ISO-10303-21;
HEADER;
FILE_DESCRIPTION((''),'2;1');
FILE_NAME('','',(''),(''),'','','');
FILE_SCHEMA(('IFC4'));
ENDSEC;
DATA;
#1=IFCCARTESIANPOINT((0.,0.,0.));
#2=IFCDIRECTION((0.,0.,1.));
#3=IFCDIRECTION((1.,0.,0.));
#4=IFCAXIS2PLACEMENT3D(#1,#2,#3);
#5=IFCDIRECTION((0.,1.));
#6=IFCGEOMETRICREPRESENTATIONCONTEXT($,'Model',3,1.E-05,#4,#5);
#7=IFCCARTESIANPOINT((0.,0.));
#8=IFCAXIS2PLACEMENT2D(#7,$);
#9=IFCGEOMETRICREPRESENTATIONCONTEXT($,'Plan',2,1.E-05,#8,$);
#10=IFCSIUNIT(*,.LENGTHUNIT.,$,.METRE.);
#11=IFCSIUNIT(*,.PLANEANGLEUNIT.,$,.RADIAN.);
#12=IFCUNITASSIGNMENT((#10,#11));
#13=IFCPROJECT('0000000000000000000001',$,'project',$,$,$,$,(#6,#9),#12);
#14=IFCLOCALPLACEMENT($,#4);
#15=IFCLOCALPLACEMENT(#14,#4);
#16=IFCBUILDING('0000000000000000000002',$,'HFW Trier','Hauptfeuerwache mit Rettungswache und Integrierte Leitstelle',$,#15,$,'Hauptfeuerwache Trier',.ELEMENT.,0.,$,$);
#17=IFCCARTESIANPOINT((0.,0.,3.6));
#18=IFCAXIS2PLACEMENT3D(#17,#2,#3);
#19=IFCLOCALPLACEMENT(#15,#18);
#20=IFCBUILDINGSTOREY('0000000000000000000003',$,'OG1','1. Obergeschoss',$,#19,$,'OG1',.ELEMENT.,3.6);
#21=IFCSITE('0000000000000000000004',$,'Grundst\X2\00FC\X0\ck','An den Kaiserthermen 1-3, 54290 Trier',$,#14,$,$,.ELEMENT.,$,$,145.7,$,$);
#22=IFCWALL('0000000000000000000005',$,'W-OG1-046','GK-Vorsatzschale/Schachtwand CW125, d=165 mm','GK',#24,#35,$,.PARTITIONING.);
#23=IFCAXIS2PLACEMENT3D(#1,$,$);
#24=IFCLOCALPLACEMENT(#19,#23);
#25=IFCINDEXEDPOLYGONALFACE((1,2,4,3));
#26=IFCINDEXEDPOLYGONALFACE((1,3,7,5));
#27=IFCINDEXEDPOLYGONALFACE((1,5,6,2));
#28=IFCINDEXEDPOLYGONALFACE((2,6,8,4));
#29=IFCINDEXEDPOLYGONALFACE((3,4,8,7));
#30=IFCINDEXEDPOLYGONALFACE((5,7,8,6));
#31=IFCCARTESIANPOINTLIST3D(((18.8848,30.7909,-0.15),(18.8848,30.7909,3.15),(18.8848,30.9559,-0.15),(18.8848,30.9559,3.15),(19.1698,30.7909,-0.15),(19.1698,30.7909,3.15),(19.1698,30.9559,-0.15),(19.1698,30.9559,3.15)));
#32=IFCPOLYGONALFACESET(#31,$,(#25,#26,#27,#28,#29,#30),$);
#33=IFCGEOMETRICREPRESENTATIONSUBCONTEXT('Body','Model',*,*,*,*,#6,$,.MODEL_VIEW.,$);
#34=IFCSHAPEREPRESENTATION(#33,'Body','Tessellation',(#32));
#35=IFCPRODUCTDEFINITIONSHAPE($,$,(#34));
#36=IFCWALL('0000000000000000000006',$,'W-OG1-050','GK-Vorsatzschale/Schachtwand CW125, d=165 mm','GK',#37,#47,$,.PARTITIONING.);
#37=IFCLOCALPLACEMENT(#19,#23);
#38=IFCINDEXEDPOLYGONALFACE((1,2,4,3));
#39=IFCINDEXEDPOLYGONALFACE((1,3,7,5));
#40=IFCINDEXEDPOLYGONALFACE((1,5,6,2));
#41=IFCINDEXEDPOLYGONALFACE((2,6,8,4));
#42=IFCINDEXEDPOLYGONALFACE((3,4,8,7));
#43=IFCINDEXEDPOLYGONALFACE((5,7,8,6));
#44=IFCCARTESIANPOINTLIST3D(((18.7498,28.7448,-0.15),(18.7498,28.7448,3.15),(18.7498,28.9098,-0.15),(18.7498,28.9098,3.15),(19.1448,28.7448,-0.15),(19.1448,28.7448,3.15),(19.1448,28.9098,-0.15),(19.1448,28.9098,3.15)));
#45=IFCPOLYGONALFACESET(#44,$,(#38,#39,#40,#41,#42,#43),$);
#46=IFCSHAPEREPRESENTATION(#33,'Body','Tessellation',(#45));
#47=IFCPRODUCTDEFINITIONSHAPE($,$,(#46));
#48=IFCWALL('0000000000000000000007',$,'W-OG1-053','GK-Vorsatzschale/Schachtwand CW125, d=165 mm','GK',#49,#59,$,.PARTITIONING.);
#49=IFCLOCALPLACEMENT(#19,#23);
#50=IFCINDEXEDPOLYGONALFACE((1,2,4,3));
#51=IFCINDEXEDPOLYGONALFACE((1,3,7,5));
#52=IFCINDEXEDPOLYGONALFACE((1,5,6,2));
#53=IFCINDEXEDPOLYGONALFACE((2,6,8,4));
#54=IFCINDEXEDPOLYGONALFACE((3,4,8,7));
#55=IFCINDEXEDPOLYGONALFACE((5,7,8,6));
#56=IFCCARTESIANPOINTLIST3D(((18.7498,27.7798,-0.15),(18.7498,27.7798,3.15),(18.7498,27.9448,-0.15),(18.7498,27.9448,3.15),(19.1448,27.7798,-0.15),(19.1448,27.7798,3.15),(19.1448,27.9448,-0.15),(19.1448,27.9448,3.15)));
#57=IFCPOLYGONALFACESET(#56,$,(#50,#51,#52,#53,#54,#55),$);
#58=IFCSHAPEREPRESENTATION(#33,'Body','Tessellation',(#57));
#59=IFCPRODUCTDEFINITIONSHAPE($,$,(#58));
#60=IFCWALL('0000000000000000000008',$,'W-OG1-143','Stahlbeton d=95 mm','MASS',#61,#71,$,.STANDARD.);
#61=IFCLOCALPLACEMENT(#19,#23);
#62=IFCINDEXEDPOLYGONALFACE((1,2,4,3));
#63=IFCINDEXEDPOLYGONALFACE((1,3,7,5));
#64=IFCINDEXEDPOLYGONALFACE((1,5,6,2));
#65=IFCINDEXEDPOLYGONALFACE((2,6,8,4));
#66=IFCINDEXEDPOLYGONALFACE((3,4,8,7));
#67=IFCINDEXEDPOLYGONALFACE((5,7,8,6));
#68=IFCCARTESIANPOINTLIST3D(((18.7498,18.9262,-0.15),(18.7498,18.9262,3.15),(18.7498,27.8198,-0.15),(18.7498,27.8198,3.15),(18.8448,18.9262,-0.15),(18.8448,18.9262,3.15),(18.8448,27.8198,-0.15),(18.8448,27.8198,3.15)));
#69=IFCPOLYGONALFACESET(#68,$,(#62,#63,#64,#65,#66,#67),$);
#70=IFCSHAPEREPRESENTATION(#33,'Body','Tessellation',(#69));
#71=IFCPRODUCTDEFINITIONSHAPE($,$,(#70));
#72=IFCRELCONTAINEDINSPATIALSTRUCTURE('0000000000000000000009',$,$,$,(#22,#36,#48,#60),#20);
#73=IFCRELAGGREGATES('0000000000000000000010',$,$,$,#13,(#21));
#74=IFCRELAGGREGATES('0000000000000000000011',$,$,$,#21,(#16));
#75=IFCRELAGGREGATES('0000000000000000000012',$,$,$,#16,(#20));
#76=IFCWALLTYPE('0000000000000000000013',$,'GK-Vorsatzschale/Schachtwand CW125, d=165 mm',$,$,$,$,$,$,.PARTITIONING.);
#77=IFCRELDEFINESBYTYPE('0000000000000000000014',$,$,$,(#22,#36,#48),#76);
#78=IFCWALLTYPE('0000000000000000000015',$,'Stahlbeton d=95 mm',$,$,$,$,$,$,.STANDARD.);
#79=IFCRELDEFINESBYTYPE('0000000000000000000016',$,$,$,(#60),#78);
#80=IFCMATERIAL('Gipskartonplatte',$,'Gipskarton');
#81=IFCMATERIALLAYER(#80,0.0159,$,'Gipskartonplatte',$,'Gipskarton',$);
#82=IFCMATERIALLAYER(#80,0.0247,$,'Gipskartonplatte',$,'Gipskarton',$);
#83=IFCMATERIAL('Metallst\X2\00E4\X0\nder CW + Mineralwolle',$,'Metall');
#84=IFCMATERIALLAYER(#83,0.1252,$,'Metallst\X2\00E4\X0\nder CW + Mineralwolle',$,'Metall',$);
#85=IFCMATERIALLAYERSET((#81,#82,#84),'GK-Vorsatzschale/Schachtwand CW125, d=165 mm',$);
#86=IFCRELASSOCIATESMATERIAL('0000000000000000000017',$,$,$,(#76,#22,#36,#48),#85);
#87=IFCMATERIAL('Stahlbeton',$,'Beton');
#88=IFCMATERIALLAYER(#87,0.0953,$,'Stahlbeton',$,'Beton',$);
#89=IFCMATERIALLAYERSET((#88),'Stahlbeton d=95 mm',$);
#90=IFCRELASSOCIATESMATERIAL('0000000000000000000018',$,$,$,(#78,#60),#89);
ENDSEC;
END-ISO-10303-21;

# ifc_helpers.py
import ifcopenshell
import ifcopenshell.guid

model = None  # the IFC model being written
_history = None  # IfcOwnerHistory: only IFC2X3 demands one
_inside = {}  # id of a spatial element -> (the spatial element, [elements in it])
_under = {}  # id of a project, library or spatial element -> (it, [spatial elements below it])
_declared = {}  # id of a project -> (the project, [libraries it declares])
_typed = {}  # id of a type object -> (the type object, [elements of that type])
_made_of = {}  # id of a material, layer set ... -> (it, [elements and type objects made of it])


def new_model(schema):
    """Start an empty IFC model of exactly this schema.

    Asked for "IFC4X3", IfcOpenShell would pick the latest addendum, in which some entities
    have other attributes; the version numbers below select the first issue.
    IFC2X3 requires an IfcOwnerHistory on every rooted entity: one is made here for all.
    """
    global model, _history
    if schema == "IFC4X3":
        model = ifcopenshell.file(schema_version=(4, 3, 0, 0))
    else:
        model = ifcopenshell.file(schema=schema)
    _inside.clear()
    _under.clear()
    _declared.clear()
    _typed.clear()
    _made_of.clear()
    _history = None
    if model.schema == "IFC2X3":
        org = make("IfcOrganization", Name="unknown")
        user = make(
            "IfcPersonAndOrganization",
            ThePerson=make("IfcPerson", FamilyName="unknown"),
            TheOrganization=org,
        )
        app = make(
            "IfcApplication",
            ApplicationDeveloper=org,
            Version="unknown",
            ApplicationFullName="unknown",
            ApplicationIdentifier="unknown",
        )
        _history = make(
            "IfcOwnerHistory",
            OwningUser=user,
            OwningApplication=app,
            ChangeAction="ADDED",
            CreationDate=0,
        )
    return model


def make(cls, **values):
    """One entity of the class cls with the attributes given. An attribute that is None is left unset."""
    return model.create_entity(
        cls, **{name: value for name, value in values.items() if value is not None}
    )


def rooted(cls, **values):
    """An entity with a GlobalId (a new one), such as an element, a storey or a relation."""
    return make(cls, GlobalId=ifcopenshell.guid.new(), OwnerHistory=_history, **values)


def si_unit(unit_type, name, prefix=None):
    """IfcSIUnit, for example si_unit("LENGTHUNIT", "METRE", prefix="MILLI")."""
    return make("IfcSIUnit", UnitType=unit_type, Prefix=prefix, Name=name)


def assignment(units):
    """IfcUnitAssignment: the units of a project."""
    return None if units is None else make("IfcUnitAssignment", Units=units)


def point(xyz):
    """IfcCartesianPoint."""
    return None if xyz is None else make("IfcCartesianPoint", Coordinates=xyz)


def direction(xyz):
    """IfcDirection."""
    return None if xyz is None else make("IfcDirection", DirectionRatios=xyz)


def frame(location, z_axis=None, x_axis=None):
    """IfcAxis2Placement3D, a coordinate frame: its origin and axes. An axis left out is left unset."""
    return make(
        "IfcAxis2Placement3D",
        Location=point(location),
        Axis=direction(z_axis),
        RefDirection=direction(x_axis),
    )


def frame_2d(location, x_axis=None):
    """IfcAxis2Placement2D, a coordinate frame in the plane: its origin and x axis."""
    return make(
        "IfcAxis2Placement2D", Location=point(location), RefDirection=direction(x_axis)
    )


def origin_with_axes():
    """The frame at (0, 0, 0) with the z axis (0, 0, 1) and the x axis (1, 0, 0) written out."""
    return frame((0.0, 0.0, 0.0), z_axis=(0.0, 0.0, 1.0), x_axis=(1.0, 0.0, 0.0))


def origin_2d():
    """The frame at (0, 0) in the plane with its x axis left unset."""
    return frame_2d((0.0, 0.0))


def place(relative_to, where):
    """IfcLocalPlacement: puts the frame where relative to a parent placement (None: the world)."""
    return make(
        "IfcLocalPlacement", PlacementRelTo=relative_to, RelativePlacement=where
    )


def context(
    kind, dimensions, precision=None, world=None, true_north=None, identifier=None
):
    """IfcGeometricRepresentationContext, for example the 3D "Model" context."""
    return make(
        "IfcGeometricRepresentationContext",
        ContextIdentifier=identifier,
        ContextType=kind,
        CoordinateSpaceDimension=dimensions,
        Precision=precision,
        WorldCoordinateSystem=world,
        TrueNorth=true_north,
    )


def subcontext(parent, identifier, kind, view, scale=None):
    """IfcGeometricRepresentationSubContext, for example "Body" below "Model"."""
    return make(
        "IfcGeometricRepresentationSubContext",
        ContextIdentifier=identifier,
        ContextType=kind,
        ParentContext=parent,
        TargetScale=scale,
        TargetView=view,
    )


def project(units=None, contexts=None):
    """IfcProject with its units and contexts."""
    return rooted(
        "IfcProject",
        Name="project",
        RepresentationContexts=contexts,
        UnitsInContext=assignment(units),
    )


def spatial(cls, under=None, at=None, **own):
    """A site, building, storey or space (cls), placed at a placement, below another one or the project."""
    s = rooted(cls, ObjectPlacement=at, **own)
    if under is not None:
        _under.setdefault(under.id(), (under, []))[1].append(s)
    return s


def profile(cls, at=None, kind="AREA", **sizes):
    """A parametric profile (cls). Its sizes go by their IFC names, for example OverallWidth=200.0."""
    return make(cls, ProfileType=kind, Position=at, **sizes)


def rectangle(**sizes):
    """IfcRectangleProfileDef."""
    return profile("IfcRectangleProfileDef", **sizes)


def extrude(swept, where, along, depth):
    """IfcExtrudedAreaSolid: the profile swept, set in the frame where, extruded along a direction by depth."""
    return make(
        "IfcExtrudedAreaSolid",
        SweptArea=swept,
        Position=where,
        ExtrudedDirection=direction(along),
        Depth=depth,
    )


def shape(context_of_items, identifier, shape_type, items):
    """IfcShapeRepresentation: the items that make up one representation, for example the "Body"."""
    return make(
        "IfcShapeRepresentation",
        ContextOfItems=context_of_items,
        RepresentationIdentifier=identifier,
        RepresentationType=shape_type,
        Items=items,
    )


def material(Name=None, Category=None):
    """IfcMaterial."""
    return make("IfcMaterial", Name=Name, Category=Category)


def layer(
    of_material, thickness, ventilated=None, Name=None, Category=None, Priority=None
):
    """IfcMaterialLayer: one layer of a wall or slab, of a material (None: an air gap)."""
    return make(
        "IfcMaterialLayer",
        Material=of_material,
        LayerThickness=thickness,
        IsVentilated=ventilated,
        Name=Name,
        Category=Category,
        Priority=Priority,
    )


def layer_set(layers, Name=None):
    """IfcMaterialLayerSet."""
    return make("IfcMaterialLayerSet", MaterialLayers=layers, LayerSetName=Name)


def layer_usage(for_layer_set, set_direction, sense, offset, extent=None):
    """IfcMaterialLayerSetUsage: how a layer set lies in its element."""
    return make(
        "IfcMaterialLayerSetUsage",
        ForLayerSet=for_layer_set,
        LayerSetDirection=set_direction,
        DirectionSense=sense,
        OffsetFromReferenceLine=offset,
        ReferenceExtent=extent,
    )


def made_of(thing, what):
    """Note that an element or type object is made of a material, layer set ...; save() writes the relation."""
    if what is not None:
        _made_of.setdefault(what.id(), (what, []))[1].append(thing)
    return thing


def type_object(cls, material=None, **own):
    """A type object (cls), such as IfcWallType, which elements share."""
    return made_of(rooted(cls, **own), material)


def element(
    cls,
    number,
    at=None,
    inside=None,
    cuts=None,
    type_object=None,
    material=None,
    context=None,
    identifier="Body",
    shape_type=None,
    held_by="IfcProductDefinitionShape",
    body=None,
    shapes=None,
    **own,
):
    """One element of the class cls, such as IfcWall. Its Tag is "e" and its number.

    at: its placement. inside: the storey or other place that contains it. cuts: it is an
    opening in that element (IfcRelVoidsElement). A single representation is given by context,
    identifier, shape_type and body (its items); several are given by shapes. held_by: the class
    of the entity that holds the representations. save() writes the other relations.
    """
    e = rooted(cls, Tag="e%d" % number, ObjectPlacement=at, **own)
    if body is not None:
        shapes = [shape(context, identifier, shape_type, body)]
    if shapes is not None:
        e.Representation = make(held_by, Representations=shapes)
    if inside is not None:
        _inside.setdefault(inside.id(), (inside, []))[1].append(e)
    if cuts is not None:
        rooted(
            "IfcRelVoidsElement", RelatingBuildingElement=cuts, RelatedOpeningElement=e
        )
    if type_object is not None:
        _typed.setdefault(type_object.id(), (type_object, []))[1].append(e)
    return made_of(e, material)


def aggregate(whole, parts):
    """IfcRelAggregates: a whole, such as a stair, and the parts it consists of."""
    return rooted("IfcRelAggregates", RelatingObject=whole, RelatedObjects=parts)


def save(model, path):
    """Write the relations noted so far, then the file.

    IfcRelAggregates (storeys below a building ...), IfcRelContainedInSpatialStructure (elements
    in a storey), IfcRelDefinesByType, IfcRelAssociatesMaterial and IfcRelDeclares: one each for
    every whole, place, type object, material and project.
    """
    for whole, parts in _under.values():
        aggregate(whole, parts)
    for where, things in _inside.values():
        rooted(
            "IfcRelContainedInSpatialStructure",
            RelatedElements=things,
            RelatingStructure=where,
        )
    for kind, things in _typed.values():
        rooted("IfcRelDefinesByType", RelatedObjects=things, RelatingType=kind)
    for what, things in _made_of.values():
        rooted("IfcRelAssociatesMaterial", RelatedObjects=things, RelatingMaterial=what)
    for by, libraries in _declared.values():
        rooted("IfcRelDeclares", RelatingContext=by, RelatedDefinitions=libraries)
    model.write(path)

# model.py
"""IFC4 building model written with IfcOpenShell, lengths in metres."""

from ifc_helpers import new_model, si_unit, direction, frame, frame_2d, origin_with_axes, origin_2d, place, context, subcontext, project, spatial, rectangle, extrude, material, layer, layer_set, layer_usage, type_object, element, save


model = new_model("IFC4")

# Units and contexts
model_context = context("Model", 3, precision=1e-05, world=origin_with_axes(), true_north=direction((0.0, 1.0)))
plan_context = context("Plan", 2, precision=1e-05, world=origin_2d())
body_context = subcontext(model_context, "Body", "Model", "MODEL_VIEW")
ifc_project = project(units=[si_unit("LENGTHUNIT", "METRE"), si_unit("PLANEANGLEUNIT", "RADIAN")], contexts=[model_context, plan_context])

# Site, building, storey
site_placement = place(None, origin_with_axes())
site = spatial("IfcSite", under=ifc_project, at=site_placement, Name="Grundstück", Description="An den Kaiserthermen 1-3, 54290 Trier", CompositionType="ELEMENT", RefElevation=145.7)
building_placement = place(site_placement, origin_with_axes())
building = spatial("IfcBuilding", under=site, at=building_placement, Name="HFW Trier", Description="Hauptfeuerwache mit Rettungswache und Integrierte Leitstelle", LongName="Hauptfeuerwache Trier", CompositionType="ELEMENT", ElevationOfRefHeight=0.0)
storey_placement = place(building_placement, frame((0.0, 0.0, 3.6), z_axis=(0.0, 0.0, 1.0), x_axis=(1.0, 0.0, 0.0)))
storey = spatial("IfcBuildingStorey", under=building, at=storey_placement, Name="OG1", Description="1. Obergeschoss", LongName="OG1", CompositionType="ELEMENT", Elevation=3.6)

# Shared definitions
ifc_material_1 = material(Name="Stahlbeton", Category="Beton")

# Shared definitions
ifc_material_2 = material(Name="Gipskartonplatte", Category="Gipskarton")
ifc_material_3 = material(Name="Metallständer CW + Mineralwolle", Category="Metall")

# Walls
ifc_layer_1 = layer(ifc_material_2, 0.0159, Name="Gipskartonplatte", Category="Gipskarton")
ifc_layer_2 = layer(ifc_material_2, 0.0247, Name="Gipskartonplatte", Category="Gipskarton")
ifc_layer_3 = layer(ifc_material_3, 0.1252, Name="Metallständer CW + Mineralwolle", Category="Metall")
ifc_layer_set_1 = layer_set([ifc_layer_1, ifc_layer_2, ifc_layer_3], Name="GK-Vorsatzschale/Schachtwand CW125, d=165 mm")
wall_type_1 = type_object("IfcWallType", Name="GK-Vorsatzschale/Schachtwand CW125, d=165 mm", PredefinedType="PARTITIONING", material=ifc_layer_set_1)
ifc_layer_usage_1 = layer_usage(ifc_layer_set_1, "AXIS2", "POSITIVE", -0.0825)
wall_1_placement = place(storey_placement, frame((18.8848, 30.8734, -0.15), z_axis=(0.0, 0.0, 1.0), x_axis=(1.0, 0.0, 0.0)))
element("IfcWall", 1, at=wall_1_placement, inside=storey, type_object=wall_type_1, material=ifc_layer_usage_1, Name="W-OG1-046", Description="GK-Vorsatzschale/Schachtwand CW125, d=165 mm", ObjectType="GK", PredefinedType="PARTITIONING", context=body_context, shape_type="SweptSolid", body=[
    extrude(rectangle(XDim=0.285, YDim=0.165, at=frame_2d((0.1425, 0.0))), origin_with_axes(), (0.0, 0.0, 1.0), 3.3),
])
ifc_layer_usage_2 = layer_usage(ifc_layer_set_1, "AXIS2", "POSITIVE", -0.0825)
wall_2_placement = place(storey_placement, frame((18.7498, 28.8273, -0.15), z_axis=(0.0, 0.0, 1.0), x_axis=(1.0, 0.0, 0.0)))
element("IfcWall", 2, at=wall_2_placement, inside=storey, type_object=wall_type_1, material=ifc_layer_usage_2, Name="W-OG1-050", Description="GK-Vorsatzschale/Schachtwand CW125, d=165 mm", ObjectType="GK", PredefinedType="PARTITIONING", context=body_context, shape_type="SweptSolid", body=[
    extrude(rectangle(XDim=0.395, YDim=0.165, at=frame_2d((0.1975, 0.0))), origin_with_axes(), (0.0, 0.0, 1.0), 3.3),
])
ifc_layer_usage_3 = layer_usage(ifc_layer_set_1, "AXIS2", "POSITIVE", -0.0825)
wall_3_placement = place(storey_placement, frame((18.7498, 27.8623, -0.15), z_axis=(0.0, 0.0, 1.0), x_axis=(1.0, 0.0, 0.0)))
element("IfcWall", 3, at=wall_3_placement, inside=storey, type_object=wall_type_1, material=ifc_layer_usage_3, Name="W-OG1-053", Description="GK-Vorsatzschale/Schachtwand CW125, d=165 mm", ObjectType="GK", PredefinedType="PARTITIONING", context=body_context, shape_type="SweptSolid", body=[
    extrude(rectangle(XDim=0.395, YDim=0.165, at=frame_2d((0.1975, 0.0))), origin_with_axes(), (0.0, 0.0, 1.0), 3.3),
])
ifc_layer_4 = layer(ifc_material_1, 0.0953, Name="Stahlbeton", Category="Beton")
ifc_layer_set_2 = layer_set([ifc_layer_4], Name="Stahlbeton d=95 mm")
ifc_layer_usage_4 = layer_usage(ifc_layer_set_2, "AXIS2", "POSITIVE", -0.0475)
wall_type_2 = type_object("IfcWallType", Name="Stahlbeton d=95 mm", PredefinedType="STANDARD", material=ifc_layer_set_2)
wall_4_placement = place(storey_placement, frame((18.7973, 27.8198, -0.15), z_axis=(0.0, 0.0, 1.0), x_axis=(0.0, -1.0, 0.0)))
element("IfcWall", 4, at=wall_4_placement, inside=storey, type_object=wall_type_2, material=ifc_layer_usage_4, Name="W-OG1-143", Description="Stahlbeton d=95 mm", ObjectType="MASS", PredefinedType="STANDARD", context=body_context, shape_type="SweptSolid", body=[
    extrude(rectangle(XDim=8.8936, YDim=0.095, at=frame_2d((4.4468, 0.0))), origin_with_axes(), (0.0, 0.0, 1.0), 3.3),
])

save(model, "model.ifc")
